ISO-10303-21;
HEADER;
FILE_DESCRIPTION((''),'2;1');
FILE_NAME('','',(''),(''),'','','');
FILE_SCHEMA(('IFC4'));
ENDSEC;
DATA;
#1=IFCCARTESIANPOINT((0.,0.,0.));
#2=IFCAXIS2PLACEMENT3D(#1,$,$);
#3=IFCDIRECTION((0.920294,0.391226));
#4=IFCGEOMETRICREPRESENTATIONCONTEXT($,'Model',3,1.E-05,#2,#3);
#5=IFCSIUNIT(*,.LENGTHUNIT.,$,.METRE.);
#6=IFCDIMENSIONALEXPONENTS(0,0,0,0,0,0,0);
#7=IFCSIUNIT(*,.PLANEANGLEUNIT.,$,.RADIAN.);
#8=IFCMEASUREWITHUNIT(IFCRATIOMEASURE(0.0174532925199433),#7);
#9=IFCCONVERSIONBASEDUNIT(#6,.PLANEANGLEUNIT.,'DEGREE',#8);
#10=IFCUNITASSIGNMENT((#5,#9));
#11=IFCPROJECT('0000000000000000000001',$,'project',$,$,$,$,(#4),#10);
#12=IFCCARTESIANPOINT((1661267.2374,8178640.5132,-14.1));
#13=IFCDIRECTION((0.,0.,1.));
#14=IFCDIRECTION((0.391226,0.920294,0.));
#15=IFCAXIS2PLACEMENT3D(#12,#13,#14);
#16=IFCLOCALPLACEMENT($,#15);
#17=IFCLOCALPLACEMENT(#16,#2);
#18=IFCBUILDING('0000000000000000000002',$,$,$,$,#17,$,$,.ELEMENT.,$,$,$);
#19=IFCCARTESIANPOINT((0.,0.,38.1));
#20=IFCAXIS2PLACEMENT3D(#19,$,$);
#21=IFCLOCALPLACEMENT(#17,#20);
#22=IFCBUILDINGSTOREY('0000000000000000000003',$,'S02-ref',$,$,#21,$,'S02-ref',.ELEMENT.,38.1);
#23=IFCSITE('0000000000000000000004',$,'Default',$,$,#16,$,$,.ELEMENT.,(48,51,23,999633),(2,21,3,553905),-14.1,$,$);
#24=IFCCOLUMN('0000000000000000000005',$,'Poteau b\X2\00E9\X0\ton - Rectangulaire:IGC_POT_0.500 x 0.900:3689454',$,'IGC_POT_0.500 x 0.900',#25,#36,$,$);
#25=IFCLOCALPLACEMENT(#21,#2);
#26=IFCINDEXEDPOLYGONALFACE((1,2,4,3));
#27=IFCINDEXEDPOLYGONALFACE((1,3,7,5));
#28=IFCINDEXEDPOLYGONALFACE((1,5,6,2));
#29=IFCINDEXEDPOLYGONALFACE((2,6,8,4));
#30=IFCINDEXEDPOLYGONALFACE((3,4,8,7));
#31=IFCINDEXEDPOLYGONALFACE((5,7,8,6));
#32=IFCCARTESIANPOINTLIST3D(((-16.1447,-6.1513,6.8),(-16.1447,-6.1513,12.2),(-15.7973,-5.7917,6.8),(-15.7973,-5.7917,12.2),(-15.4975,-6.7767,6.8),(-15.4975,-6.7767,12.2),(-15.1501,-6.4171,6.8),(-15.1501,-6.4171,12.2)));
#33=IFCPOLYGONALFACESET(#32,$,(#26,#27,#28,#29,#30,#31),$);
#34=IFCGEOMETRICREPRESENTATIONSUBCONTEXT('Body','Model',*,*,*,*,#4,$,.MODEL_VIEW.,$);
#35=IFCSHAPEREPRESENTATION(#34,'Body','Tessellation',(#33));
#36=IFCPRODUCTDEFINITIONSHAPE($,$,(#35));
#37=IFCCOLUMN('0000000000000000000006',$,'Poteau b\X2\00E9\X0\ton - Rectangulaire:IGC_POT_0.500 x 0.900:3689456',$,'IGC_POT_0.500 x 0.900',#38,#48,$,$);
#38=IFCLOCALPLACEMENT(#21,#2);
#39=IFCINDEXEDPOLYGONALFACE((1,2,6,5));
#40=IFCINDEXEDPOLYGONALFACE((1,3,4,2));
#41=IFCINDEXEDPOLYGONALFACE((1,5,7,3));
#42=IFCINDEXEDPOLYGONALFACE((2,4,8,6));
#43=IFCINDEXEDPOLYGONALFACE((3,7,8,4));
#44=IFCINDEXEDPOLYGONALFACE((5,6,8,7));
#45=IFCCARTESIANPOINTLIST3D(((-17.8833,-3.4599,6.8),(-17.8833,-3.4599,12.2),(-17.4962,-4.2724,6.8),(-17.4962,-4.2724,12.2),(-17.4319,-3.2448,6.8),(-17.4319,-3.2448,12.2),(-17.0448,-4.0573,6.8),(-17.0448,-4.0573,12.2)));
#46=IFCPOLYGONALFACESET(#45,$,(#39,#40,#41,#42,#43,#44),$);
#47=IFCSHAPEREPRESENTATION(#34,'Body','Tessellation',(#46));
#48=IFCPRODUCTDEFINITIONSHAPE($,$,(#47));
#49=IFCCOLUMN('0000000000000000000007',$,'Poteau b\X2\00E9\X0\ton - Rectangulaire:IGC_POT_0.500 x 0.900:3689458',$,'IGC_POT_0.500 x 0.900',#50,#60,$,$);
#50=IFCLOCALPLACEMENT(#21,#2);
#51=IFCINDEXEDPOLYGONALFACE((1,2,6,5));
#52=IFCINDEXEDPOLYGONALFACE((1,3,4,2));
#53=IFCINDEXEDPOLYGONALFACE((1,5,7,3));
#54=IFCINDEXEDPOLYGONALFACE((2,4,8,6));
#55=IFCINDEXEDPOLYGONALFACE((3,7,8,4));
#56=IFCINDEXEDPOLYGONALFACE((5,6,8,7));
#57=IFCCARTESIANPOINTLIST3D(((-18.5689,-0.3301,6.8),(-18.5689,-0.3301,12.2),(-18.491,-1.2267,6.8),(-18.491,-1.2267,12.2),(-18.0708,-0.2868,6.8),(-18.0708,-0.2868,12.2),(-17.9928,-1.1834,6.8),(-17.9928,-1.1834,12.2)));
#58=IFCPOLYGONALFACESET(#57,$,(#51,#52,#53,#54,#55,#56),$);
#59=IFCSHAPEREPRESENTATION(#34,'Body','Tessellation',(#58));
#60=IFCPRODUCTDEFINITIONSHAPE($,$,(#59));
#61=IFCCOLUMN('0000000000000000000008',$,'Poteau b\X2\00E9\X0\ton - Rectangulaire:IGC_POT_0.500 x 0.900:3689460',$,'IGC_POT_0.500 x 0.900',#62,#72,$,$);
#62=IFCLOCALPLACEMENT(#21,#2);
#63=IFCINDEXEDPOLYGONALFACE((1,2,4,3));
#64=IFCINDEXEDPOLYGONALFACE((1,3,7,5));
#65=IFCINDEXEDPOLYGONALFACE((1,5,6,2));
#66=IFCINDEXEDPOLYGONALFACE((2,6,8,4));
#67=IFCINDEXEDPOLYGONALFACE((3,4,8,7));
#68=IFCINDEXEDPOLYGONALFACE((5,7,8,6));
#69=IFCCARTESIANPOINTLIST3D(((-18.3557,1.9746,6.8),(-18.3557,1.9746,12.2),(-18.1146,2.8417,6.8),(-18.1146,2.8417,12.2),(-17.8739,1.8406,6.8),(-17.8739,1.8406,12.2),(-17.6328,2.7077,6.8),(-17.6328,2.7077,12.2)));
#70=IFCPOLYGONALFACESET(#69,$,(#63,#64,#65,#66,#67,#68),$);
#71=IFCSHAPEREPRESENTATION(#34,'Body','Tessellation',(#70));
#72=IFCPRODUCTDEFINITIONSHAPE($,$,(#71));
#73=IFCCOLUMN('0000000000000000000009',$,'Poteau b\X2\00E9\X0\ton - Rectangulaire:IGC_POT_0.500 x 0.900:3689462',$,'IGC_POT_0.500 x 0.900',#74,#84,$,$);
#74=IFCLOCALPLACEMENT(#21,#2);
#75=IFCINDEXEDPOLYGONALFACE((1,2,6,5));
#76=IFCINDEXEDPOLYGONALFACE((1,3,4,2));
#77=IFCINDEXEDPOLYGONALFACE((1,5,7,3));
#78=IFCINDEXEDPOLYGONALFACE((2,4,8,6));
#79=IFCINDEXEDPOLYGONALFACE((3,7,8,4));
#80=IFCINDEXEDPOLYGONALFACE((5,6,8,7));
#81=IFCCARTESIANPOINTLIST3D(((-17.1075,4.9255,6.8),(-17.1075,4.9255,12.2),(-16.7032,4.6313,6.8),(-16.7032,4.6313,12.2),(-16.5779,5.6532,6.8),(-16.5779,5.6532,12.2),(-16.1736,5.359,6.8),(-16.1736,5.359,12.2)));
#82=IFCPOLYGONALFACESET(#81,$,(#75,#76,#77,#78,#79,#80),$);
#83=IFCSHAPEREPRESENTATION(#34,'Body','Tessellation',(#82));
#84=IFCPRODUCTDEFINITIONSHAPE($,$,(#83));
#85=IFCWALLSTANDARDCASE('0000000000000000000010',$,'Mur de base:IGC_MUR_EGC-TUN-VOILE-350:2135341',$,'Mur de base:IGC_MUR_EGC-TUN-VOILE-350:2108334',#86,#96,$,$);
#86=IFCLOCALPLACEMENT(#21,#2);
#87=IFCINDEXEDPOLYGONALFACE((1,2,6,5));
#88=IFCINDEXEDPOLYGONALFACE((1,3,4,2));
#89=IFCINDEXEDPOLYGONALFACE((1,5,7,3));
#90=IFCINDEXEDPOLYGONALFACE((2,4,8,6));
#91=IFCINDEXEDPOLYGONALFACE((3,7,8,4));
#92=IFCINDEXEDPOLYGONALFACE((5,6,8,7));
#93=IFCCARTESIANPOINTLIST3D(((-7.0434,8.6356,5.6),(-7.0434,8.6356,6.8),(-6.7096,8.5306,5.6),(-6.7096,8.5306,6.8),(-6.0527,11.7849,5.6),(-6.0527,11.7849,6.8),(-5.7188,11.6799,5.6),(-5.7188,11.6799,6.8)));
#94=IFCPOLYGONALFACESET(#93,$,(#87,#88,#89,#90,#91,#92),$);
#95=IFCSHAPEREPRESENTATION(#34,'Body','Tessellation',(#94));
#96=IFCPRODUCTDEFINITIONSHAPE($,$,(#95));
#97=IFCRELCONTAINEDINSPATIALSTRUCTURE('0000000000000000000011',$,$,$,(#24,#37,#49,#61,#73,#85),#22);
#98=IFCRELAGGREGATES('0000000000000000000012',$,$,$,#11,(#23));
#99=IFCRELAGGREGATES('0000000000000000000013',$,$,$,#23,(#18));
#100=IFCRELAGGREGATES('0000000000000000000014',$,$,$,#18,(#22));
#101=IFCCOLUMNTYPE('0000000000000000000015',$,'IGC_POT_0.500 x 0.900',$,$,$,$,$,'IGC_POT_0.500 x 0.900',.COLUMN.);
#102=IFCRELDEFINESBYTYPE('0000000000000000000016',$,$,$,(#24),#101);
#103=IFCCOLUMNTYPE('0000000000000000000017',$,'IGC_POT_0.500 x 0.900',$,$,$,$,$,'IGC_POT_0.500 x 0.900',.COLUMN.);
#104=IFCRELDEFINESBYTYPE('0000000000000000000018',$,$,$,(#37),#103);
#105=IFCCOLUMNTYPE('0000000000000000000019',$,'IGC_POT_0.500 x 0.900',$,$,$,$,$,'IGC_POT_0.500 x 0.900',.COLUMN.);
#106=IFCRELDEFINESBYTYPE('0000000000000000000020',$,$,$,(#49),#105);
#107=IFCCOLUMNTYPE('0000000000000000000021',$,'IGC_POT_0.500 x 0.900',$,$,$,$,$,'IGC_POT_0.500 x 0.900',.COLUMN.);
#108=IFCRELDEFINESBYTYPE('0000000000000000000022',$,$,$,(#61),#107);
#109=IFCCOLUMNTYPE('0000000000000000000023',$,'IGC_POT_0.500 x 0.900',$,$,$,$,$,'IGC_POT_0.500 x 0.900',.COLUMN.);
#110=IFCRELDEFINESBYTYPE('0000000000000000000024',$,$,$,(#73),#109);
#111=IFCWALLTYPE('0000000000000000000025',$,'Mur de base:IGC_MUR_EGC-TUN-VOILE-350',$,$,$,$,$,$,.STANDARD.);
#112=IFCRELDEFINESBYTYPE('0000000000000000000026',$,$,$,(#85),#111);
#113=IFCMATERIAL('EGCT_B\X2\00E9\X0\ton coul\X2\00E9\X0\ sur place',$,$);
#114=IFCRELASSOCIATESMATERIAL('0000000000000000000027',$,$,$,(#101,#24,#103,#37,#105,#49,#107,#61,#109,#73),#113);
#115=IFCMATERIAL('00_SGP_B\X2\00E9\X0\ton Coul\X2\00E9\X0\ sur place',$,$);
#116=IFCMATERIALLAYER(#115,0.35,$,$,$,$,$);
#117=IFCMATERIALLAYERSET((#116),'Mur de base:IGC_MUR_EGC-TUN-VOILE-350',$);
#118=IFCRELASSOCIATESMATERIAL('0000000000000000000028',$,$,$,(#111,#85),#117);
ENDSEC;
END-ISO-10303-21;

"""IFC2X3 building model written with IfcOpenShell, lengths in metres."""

from ifc_helpers import new_model, entity, si_unit, converted_unit, direction, frame, frame_2d, origin, origin_2d_with_axis, place, context, subcontext, project, spatial, rectangle, extrude, source, transform, mapped, material, layer, layer_set, layer_usage, type_object, type_shapes, element, save


model = new_model("IFC2X3")

# Units and contexts
model_context = context("Model", 3, precision=1e-05, world=origin(), true_north=direction((0.920294, 0.391226)))
body_context = subcontext(model_context, "Body", "Model", "MODEL_VIEW")
ifc_project = project(units=[si_unit("LENGTHUNIT", "METRE"), converted_unit("PLANEANGLEUNIT", "DEGREE", entity("IfcRatioMeasure", 0.0174532925199433), si_unit("PLANEANGLEUNIT", "RADIAN"), dimensions=[0, 0, 0, 0, 0, 0, 0])], contexts=[model_context])

# Site, building, storey
site_placement = place(None, frame((1661267.2374, 8178640.5132, -14.1), z_axis=(0.0, 0.0, 1.0), x_axis=(0.391226, 0.920294, 0.0)))
site = spatial("IfcSite", under=ifc_project, at=site_placement, Name="Default", CompositionType="ELEMENT", RefLatitude=(48, 51, 23, 999633), RefLongitude=(2, 21, 3, 553905), RefElevation=-14.1)
building_placement = place(site_placement, origin())
building = spatial("IfcBuilding", under=site, at=building_placement, CompositionType="ELEMENT")
storey_placement = place(building_placement, frame((0.0, 0.0, 38.1)))
storey = spatial("IfcBuildingStorey", under=building, at=storey_placement, Name="S02-ref", LongName="S02-ref", CompositionType="ELEMENT", Elevation=38.1)

# Columns
ifc_material_1 = material(Name="EGCT_Béton coulé sur place")
column_type_1 = type_object("IfcColumnType", Name="IGC_POT_0.500 x 0.900", ElementType="IGC_POT_0.500 x 0.900", PredefinedType="COLUMN", material=ifc_material_1)
shared_shape_1 = source(origin(), body_context, "Body", "SweptSolid", [
    extrude(rectangle(XDim=0.9, YDim=0.5, at=origin_2d_with_axis()), frame((-15.6474, -6.2842, 44.9), z_axis=(0.0, 0.0, 1.0), x_axis=(-0.719121, 0.694885, 0.0)), (0.0, 0.0, 1.0), 5.4),
])
type_shapes(column_type_1, [shared_shape_1])
column_1_placement = place(storey_placement, frame((0.0, 0.0, -38.1)))
element("IfcColumn", 1, at=column_1_placement, inside=storey, type_object=column_type_1, material=ifc_material_1, Name="Poteau béton - Rectangulaire:IGC_POT_0.500 x 0.900:3689454", ObjectType="IGC_POT_0.500 x 0.900", context=body_context, shape_type="MappedRepresentation", body=[
    mapped(shared_shape_1, transform((0.0, 0.0, 0.0), scale=1.0)),
])
column_type_2 = type_object("IfcColumnType", Name="IGC_POT_0.500 x 0.900", ElementType="IGC_POT_0.500 x 0.900", PredefinedType="COLUMN", material=ifc_material_1)
shared_shape_2 = source(origin(), body_context, "Body", "SweptSolid", [
    extrude(rectangle(XDim=0.9, YDim=0.5, at=frame_2d((0.0, 0.0), x_axis=(1.0, 0.0))), frame((-17.4641, -3.7586, 44.9), z_axis=(0.0, 0.0, 1.0), x_axis=(-0.430108, 0.902777, 0.0)), (0.0, 0.0, 1.0), 5.4),
])
type_shapes(column_type_2, [shared_shape_2])
column_2_placement = place(storey_placement, frame((0.0, 0.0, -38.1)))
element("IfcColumn", 2, at=column_2_placement, inside=storey, type_object=column_type_2, material=ifc_material_1, Name="Poteau béton - Rectangulaire:IGC_POT_0.500 x 0.900:3689456", ObjectType="IGC_POT_0.500 x 0.900", context=body_context, shape_type="MappedRepresentation", body=[
    mapped(shared_shape_2, transform((0.0, 0.0, 0.0), scale=1.0)),
])
column_type_3 = type_object("IfcColumnType", Name="IGC_POT_0.500 x 0.900", ElementType="IGC_POT_0.500 x 0.900", PredefinedType="COLUMN", material=ifc_material_1)
shared_shape_3 = source(origin(), body_context, "Body", "SweptSolid", [
    extrude(rectangle(XDim=0.9, YDim=0.5, at=frame_2d((0.0, 0.0), x_axis=(1.0, 0.0))), frame((-18.2809, -0.7567, 44.9), z_axis=(0.0, 0.0, 1.0), x_axis=(-0.086594, 0.996244, 0.0)), (0.0, 0.0, 1.0), 5.4),
])
type_shapes(column_type_3, [shared_shape_3])
column_3_placement = place(storey_placement, frame((0.0, 0.0, -38.1)))
element("IfcColumn", 3, at=column_3_placement, inside=storey, type_object=column_type_3, material=ifc_material_1, Name="Poteau béton - Rectangulaire:IGC_POT_0.500 x 0.900:3689458", ObjectType="IGC_POT_0.500 x 0.900", context=body_context, shape_type="MappedRepresentation", body=[
    mapped(shared_shape_3, transform((0.0, 0.0, 0.0), scale=1.0)),
])
column_type_4 = type_object("IfcColumnType", Name="IGC_POT_0.500 x 0.900", ElementType="IGC_POT_0.500 x 0.900", PredefinedType="COLUMN", material=ifc_material_1)
shared_shape_4 = source(origin(), body_context, "Body", "SweptSolid", [
    extrude(rectangle(XDim=0.5, YDim=0.9, at=frame_2d((0.0, 0.0), x_axis=(1.0, 0.0))), frame((-17.9943, 2.3411, 44.9), z_axis=(0.0, 0.0, 1.0), x_axis=(-0.963446, 0.267904, 0.0)), (0.0, 0.0, 1.0), 5.4),
])
type_shapes(column_type_4, [shared_shape_4])
column_4_placement = place(storey_placement, frame((0.0, 0.0, -38.1)))
element("IfcColumn", 4, at=column_4_placement, inside=storey, type_object=column_type_4, material=ifc_material_1, Name="Poteau béton - Rectangulaire:IGC_POT_0.500 x 0.900:3689460", ObjectType="IGC_POT_0.500 x 0.900", context=body_context, shape_type="MappedRepresentation", body=[
    mapped(shared_shape_4, transform((0.0, 0.0, 0.0), scale=1.0)),
])
column_type_5 = type_object("IfcColumnType", Name="IGC_POT_0.500 x 0.900", ElementType="IGC_POT_0.500 x 0.900", PredefinedType="COLUMN", material=ifc_material_1)
shared_shape_5 = source(origin(), body_context, "Body", "SweptSolid", [
    extrude(rectangle(XDim=0.5, YDim=0.9, at=frame_2d((0.0, 0.0), x_axis=(1.0, 0.0))), frame((-16.6405, 5.1423, 44.9), z_axis=(0.0, 0.0, 1.0), x_axis=(-0.808536, 0.588447, 0.0)), (0.0, 0.0, 1.0), 5.4),
])
type_shapes(column_type_5, [shared_shape_5])
column_5_placement = place(storey_placement, frame((0.0, 0.0, -38.1)))
element("IfcColumn", 5, at=column_5_placement, inside=storey, type_object=column_type_5, material=ifc_material_1, Name="Poteau béton - Rectangulaire:IGC_POT_0.500 x 0.900:3689462", ObjectType="IGC_POT_0.500 x 0.900", context=body_context, shape_type="MappedRepresentation", body=[
    mapped(shared_shape_5, transform((0.0, 0.0, 0.0), scale=1.0)),
])

# Shared definitions
ifc_material_2 = material(Name="00_SGP_Béton Coulé sur place")

# Wall
ifc_layer_1 = layer(ifc_material_2, 0.35)
ifc_layer_set_1 = layer_set([ifc_layer_1], Name="Mur de base:IGC_MUR_EGC-TUN-VOILE-350")
ifc_layer_usage_1 = layer_usage(ifc_layer_set_1, "AXIS2", "POSITIVE", -0.175)
wall_type = type_object("IfcWallType", Name="Mur de base:IGC_MUR_EGC-TUN-VOILE-350", PredefinedType="STANDARD", material=ifc_layer_set_1)
wall_1_placement = place(storey_placement, frame((-6.8765, 8.5831, 5.6), z_axis=(0.0, 0.0, 1.0), x_axis=(0.300085, 0.953913, 0.0)))
element("IfcWallStandardCase", 6, at=wall_1_placement, inside=storey, type_object=wall_type, material=ifc_layer_usage_1, Name="Mur de base:IGC_MUR_EGC-TUN-VOILE-350:2135341", ObjectType="Mur de base:IGC_MUR_EGC-TUN-VOILE-350:2108334", context=body_context, shape_type="SweptSolid", body=[
    extrude(rectangle(XDim=3.3015, YDim=0.35, at=frame_2d((1.6507, 0.0), x_axis=(-1.0, 0.0))), origin(), (0.0, 0.0, 1.0), 1.2),
])

save(model, "model.ifc")
